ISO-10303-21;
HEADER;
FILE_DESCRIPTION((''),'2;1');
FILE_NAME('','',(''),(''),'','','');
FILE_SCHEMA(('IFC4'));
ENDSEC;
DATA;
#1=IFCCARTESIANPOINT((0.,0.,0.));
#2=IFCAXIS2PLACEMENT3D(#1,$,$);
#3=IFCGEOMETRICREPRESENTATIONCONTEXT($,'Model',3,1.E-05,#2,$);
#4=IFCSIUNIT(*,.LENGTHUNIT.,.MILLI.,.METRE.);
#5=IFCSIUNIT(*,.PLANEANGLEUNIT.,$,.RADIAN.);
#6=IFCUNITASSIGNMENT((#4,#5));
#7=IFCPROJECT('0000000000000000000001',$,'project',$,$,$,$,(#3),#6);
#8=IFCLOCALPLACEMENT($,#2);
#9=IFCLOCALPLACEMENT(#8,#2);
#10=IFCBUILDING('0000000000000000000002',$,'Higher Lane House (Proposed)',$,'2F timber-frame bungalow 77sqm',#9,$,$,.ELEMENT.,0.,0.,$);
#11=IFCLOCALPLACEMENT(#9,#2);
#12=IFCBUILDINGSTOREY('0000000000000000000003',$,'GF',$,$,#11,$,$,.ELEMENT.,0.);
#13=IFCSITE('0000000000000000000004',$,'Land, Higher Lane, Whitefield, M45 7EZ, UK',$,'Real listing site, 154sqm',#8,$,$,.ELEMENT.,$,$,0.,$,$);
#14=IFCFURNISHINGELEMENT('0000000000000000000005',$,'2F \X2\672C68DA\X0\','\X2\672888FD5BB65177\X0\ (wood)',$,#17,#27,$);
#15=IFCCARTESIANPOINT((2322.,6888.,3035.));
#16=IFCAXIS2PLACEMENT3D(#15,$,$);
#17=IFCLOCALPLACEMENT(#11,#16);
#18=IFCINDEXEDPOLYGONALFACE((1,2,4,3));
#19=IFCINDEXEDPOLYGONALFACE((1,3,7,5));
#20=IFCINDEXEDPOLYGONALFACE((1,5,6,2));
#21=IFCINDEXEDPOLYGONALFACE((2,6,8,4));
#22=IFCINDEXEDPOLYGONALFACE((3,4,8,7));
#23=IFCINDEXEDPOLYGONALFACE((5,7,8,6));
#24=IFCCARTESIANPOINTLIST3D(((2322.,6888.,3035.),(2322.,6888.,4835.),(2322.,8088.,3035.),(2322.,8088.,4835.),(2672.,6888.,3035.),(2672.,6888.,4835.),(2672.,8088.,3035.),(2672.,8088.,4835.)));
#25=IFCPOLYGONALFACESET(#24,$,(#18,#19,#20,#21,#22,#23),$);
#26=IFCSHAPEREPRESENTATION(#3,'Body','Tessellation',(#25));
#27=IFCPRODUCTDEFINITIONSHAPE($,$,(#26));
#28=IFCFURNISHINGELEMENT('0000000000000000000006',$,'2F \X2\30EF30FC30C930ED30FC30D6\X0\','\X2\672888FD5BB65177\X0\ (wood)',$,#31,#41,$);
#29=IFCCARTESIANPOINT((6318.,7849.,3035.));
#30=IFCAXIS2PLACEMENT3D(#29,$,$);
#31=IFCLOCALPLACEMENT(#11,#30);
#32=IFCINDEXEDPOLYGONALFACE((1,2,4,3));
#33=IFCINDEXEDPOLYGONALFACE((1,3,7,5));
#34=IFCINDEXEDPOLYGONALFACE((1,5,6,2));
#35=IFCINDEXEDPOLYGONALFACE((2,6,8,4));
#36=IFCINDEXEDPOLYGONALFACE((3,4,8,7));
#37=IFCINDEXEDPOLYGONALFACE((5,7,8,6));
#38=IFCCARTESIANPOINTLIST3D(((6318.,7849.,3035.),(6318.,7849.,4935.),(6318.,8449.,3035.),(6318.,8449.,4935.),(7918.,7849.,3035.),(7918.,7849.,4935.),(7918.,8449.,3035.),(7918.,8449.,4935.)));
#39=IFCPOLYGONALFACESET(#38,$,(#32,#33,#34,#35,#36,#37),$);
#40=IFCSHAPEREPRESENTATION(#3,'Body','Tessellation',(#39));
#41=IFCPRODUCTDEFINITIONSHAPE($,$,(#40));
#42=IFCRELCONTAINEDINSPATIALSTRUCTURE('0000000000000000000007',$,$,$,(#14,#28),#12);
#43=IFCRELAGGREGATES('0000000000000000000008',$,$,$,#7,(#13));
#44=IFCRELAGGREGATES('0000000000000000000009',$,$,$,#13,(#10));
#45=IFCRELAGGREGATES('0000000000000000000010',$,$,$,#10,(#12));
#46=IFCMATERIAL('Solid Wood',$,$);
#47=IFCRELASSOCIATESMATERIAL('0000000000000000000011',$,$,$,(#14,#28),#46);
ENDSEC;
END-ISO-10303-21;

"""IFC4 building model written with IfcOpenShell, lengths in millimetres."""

from ifc_helpers import new_model, si_unit, frame, frame_2d, origin, place, context, project, spatial, rectangle, extrude, material, element, save


model = new_model("IFC4")

# Units and contexts
model_context = context("Model", 3, precision=1e-05, world=origin())
ifc_project = project(units=[si_unit("LENGTHUNIT", "METRE", prefix="MILLI"), si_unit("PLANEANGLEUNIT", "RADIAN")], contexts=[model_context])

# Site, building, storey
site_placement = place(None, origin())
site = spatial("IfcSite", under=ifc_project, at=site_placement, Name="Land, Higher Lane, Whitefield, M45 7EZ, UK", ObjectType="Real listing site, 154sqm", CompositionType="ELEMENT", RefElevation=0.0)
building_placement = place(site_placement, origin())
building = spatial("IfcBuilding", under=site, at=building_placement, Name="Higher Lane House (Proposed)", ObjectType="2F timber-frame bungalow 77sqm", CompositionType="ELEMENT", ElevationOfRefHeight=0.0, ElevationOfTerrain=0.0)
storey_placement = place(building_placement, origin())
storey = spatial("IfcBuildingStorey", under=building, at=storey_placement, Name="GF", CompositionType="ELEMENT", Elevation=0.0)

# Shared definitions
ifc_material_1 = material(Name="Solid Wood")

# Furnishing elements
furnishing_1_placement = place(storey_placement, frame((2322.0, 6888.0, 3035.0)))
element("IfcFurnishingElement", 1, at=furnishing_1_placement, inside=storey, material=ifc_material_1, Name="2F 本棚", Description="木製家具 (wood)", context=model_context, shape_type="SweptSolid", body=[
    extrude(rectangle(XDim=350.0, YDim=1200.0, at=frame_2d((175.0, 600.0))), frame((2322.0, 6888.0, 3035.0)), (0.0, 0.0, 1.0), 1800.0),
])
furnishing_2_placement = place(storey_placement, frame((6318.0, 7849.0, 3035.0)))
element("IfcFurnishingElement", 2, at=furnishing_2_placement, inside=storey, material=ifc_material_1, Name="2F ワードローブ", Description="木製家具 (wood)", context=model_context, shape_type="SweptSolid", body=[
    extrude(rectangle(XDim=1600.0, YDim=600.0, at=frame_2d((800.0, 300.0))), frame((6318.0, 7849.0, 3035.0)), (0.0, 0.0, 1.0), 1900.0),
])

save(model, "model.ifc")
